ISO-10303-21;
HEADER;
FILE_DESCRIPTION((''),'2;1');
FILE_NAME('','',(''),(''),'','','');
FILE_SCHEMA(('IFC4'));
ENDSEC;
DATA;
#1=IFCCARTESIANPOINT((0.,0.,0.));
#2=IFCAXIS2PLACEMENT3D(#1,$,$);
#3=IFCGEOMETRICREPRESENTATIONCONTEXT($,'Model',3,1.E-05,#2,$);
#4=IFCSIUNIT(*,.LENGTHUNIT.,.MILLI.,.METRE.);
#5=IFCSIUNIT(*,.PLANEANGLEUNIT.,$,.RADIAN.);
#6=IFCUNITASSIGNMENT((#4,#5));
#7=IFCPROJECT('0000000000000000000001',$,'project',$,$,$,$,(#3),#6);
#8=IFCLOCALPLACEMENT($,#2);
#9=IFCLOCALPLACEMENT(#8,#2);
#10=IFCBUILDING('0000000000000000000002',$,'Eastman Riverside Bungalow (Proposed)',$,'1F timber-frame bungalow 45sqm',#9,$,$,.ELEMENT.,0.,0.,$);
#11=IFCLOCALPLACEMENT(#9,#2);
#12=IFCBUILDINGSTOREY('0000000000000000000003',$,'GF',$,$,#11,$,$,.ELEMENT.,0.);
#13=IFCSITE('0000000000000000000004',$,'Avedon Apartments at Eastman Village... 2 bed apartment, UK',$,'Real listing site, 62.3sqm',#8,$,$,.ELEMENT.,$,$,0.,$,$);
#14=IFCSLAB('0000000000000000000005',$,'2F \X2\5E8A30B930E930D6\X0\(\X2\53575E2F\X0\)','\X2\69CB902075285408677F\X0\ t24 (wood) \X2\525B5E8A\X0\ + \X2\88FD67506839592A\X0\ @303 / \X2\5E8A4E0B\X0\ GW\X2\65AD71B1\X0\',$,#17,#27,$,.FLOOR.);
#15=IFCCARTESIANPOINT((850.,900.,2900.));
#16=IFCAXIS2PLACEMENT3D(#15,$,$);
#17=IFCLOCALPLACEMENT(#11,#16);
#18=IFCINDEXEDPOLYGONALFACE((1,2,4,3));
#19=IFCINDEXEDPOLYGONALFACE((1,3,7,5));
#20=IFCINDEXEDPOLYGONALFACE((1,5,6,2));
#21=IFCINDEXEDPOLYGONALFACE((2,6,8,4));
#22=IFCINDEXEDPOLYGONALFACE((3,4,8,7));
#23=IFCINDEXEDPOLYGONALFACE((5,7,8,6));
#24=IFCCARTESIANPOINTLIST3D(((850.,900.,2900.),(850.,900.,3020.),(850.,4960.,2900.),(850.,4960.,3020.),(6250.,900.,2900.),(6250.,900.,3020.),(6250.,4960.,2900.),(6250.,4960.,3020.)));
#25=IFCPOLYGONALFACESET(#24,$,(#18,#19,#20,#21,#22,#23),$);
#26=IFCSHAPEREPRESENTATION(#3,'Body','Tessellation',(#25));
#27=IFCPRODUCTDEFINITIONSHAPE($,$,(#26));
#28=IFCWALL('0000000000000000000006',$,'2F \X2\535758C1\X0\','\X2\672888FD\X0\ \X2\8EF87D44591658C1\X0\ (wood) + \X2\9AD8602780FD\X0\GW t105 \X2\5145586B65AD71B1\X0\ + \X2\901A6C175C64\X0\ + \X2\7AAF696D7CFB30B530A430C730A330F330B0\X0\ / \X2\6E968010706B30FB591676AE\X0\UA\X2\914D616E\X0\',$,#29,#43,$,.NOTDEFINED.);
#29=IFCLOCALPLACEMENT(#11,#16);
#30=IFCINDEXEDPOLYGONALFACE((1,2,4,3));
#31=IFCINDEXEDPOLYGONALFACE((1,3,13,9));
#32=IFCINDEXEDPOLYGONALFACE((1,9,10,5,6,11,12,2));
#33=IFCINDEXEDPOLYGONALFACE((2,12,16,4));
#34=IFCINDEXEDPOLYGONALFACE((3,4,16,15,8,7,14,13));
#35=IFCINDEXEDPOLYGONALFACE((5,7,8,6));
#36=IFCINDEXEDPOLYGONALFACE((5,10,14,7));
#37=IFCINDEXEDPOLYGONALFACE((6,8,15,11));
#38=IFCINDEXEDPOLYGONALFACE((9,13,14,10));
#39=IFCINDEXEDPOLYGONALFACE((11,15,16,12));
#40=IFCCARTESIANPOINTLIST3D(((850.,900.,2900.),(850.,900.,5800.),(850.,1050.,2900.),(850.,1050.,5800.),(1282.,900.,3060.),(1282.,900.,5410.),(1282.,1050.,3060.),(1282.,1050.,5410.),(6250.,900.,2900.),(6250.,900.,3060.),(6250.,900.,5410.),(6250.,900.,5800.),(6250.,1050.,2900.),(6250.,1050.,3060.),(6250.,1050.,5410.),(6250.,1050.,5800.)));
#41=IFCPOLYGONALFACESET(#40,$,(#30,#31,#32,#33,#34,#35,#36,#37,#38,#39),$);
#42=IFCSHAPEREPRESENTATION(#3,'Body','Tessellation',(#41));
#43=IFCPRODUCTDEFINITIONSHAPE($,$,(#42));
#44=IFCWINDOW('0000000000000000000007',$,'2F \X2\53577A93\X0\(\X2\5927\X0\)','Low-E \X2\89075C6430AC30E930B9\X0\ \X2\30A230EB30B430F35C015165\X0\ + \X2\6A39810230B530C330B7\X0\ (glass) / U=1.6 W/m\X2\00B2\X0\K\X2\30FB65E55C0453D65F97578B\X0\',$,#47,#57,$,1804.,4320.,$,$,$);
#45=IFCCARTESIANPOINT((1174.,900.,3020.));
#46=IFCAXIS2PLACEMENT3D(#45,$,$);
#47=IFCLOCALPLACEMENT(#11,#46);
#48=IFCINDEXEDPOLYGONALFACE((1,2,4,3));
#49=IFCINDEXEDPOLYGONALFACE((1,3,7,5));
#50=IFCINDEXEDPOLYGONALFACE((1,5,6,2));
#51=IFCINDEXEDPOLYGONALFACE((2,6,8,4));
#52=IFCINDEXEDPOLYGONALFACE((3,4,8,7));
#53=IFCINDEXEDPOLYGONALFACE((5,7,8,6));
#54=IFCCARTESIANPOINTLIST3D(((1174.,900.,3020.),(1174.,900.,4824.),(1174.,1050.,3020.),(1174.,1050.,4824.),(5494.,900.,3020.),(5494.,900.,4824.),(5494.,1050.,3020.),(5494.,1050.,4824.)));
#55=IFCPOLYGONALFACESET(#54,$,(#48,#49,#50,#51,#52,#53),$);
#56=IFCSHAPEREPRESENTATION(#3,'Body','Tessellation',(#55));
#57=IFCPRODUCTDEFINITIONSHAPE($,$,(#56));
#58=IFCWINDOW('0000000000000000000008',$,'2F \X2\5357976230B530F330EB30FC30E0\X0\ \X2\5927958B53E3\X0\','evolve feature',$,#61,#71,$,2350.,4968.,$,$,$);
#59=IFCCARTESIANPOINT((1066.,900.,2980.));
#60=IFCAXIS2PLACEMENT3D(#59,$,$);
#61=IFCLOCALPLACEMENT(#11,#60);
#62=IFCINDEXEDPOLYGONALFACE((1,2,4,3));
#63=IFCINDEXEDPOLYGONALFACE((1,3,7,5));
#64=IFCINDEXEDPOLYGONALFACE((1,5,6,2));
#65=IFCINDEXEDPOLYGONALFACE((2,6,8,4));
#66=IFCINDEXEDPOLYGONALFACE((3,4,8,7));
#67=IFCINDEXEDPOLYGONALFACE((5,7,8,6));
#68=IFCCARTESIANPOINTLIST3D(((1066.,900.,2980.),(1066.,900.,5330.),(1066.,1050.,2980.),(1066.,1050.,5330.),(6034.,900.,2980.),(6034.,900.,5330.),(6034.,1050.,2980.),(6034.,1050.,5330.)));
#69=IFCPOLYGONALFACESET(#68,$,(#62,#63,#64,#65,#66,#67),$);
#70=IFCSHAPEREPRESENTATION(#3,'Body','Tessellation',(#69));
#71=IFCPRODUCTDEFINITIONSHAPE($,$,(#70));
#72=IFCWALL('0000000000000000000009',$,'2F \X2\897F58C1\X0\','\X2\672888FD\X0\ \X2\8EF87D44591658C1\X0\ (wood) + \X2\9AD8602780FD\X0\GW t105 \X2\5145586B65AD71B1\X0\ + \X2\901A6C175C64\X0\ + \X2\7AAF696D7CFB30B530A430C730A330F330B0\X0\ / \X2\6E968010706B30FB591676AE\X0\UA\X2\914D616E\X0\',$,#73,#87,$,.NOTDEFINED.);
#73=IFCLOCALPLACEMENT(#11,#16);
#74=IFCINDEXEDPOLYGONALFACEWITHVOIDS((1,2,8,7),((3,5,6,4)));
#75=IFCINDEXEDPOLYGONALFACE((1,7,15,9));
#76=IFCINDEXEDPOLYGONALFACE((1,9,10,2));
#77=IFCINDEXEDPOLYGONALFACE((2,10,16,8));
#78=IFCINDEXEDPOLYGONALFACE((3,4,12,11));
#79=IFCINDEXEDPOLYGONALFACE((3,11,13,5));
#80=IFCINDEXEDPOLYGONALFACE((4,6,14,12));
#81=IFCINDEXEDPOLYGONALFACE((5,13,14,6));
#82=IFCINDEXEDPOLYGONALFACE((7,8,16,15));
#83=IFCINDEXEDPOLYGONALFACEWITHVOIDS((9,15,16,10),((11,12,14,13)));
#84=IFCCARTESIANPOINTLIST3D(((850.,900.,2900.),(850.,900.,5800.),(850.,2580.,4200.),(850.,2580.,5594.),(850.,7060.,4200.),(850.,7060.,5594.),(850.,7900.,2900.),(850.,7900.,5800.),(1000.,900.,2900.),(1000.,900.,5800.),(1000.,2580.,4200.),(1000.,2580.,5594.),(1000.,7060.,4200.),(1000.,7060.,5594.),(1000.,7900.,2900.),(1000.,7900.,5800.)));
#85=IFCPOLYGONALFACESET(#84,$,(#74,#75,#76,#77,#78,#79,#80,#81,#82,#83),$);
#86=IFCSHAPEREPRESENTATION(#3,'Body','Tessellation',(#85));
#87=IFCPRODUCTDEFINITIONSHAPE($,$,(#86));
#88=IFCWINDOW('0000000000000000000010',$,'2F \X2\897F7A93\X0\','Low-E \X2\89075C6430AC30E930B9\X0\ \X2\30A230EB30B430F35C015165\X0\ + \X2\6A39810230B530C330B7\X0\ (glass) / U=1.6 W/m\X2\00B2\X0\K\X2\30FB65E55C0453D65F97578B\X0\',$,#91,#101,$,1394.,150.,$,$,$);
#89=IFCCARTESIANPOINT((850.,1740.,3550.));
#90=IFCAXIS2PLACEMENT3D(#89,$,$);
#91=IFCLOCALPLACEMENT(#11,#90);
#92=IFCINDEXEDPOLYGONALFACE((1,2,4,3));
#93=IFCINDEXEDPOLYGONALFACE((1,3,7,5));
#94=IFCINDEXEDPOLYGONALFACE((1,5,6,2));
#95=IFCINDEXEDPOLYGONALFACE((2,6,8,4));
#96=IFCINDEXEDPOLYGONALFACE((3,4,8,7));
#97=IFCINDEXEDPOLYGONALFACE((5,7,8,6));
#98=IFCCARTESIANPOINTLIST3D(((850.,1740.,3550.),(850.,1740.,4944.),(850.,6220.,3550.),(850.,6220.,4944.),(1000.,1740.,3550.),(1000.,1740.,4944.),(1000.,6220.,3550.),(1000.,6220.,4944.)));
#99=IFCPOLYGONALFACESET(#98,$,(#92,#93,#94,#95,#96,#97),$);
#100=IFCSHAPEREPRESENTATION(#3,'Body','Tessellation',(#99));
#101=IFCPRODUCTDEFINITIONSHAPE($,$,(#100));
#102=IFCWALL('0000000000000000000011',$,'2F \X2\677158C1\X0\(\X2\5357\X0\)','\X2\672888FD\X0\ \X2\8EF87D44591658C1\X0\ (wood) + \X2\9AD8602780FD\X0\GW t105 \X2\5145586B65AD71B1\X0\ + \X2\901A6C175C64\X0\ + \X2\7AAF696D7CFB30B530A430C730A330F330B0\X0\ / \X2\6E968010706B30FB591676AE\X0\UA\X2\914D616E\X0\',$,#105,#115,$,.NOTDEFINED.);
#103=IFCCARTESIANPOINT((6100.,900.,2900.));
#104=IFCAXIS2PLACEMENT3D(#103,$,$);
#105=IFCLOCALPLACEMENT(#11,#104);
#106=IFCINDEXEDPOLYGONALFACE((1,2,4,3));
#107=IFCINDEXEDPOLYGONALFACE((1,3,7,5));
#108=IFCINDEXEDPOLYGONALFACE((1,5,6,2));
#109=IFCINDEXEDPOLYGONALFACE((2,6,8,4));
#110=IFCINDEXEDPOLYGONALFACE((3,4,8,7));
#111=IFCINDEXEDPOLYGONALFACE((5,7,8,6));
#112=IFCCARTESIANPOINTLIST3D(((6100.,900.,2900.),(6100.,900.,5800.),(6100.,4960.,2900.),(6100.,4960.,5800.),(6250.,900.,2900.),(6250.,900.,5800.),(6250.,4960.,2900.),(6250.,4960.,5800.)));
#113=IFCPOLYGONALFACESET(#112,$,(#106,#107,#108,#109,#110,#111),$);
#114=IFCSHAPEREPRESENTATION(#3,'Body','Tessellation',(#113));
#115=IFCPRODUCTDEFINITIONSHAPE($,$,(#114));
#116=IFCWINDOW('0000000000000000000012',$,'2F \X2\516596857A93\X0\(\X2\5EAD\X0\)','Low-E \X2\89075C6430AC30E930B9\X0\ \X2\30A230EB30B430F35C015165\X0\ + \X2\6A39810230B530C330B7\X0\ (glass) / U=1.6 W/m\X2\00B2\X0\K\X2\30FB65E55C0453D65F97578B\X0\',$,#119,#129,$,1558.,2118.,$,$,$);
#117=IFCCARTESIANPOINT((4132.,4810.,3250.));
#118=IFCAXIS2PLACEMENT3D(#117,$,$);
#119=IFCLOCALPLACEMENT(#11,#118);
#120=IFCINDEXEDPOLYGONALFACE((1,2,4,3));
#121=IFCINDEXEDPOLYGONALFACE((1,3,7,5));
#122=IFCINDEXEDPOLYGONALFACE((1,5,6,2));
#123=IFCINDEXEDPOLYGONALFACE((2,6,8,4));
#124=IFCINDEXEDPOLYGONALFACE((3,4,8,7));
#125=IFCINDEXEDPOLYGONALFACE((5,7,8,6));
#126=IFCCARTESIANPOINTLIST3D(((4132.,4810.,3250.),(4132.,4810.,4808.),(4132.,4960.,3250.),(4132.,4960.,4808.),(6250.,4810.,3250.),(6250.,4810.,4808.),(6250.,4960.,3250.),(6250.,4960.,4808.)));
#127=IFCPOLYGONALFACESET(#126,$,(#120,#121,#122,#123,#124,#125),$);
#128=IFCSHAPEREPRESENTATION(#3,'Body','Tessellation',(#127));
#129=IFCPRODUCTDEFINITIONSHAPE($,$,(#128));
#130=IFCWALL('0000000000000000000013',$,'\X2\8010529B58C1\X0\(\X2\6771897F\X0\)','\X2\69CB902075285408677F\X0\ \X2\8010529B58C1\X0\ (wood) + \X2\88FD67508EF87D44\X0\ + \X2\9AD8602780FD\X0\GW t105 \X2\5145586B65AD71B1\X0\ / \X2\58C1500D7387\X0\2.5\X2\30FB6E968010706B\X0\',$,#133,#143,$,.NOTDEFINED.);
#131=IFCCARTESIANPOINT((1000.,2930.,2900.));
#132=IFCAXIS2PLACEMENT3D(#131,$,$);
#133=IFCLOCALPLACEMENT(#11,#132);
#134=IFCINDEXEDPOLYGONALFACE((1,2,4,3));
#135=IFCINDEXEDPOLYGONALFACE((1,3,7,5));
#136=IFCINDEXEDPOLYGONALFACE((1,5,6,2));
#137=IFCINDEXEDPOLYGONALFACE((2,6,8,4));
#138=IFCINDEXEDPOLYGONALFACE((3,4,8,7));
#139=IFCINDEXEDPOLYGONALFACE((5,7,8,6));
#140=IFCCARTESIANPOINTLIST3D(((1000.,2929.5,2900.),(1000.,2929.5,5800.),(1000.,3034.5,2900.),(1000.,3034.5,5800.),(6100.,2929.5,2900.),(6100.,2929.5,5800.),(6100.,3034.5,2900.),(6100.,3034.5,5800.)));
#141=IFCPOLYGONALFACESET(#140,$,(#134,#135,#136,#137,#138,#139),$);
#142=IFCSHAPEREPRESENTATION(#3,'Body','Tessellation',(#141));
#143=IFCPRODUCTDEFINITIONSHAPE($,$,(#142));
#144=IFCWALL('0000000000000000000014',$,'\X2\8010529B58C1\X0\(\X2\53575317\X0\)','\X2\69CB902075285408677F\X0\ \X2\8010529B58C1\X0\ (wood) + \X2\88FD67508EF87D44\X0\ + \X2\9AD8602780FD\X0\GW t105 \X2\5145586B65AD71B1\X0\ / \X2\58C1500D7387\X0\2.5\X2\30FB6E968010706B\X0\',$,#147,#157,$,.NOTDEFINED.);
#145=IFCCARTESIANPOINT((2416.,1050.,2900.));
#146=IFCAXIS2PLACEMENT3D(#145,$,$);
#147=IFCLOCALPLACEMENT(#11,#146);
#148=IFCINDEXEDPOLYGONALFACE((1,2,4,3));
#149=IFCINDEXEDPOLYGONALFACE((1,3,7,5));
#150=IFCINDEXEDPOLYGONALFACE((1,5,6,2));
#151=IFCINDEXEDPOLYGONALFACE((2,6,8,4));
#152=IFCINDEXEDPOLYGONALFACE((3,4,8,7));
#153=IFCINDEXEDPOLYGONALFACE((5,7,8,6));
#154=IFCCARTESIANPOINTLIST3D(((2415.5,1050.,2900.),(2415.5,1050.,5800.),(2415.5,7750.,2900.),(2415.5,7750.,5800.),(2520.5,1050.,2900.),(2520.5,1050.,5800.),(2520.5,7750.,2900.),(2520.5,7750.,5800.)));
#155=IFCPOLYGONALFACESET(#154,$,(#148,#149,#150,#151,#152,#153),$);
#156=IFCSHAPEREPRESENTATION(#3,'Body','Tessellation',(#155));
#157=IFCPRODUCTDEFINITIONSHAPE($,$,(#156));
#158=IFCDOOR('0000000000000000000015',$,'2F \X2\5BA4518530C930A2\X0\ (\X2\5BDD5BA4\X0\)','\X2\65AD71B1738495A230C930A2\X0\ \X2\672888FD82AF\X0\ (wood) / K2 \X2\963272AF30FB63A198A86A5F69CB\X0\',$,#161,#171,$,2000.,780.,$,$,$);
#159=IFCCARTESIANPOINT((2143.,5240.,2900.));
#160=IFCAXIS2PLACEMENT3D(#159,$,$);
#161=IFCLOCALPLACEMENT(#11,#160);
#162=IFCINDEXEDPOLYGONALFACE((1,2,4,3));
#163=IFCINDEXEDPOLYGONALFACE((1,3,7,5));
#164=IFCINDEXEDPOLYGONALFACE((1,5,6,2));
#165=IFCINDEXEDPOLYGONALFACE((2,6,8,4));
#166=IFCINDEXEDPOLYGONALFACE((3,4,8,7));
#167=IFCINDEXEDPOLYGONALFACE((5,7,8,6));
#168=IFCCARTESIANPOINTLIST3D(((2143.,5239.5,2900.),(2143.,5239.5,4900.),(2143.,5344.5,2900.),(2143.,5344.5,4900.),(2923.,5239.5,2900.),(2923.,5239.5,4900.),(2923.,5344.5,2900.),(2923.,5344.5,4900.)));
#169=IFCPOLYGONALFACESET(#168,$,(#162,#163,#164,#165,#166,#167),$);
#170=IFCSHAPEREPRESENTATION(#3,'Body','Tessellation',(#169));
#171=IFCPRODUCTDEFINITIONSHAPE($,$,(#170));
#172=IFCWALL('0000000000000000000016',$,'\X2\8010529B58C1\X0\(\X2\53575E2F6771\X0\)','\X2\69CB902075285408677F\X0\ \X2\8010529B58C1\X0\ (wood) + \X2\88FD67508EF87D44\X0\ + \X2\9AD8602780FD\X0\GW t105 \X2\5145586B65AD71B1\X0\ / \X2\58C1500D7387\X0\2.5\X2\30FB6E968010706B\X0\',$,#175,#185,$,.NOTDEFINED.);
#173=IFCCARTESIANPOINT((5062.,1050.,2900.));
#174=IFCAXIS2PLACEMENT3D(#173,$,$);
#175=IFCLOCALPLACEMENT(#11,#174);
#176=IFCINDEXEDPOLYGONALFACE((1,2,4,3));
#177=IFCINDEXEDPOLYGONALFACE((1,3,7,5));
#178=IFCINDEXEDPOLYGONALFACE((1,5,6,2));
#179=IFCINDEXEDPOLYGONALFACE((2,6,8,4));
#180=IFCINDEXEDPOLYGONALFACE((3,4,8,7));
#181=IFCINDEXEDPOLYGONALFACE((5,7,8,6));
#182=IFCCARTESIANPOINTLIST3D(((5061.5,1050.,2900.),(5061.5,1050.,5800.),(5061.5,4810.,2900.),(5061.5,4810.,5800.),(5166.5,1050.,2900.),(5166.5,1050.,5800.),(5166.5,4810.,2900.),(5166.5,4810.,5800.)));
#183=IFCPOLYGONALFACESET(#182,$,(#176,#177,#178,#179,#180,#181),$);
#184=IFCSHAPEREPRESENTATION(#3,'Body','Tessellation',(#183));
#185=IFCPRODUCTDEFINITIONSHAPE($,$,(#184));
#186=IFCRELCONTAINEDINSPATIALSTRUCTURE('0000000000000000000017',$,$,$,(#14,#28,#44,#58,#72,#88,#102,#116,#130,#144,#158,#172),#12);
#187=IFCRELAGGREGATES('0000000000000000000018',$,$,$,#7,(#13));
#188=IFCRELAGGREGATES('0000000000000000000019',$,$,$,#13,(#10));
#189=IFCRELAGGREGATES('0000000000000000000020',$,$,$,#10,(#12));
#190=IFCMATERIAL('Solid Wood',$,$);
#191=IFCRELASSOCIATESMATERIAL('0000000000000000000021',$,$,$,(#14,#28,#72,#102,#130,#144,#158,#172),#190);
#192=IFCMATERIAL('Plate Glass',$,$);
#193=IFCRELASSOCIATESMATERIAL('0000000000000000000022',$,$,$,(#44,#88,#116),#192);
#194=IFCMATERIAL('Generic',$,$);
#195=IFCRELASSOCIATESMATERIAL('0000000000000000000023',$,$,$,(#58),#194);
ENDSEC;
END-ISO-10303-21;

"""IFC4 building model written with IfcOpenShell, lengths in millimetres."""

from ifc_helpers import new_model, si_unit, frame, frame_2d, origin, place, context, project, spatial, rectangle, extrude, material, element, fill, save


model = new_model("IFC4")

# Units and contexts
model_context = context("Model", 3, precision=1e-05, world=origin())
ifc_project = project(units=[si_unit("LENGTHUNIT", "METRE", prefix="MILLI"), si_unit("PLANEANGLEUNIT", "RADIAN")], contexts=[model_context])

# Site, building, storey
site_placement = place(None, origin())
site = spatial("IfcSite", under=ifc_project, at=site_placement, Name="Avedon Apartments at Eastman Village... 2 bed apartment, UK", ObjectType="Real listing site, 62.3sqm", CompositionType="ELEMENT", RefElevation=0.0)
building_placement = place(site_placement, origin())
building = spatial("IfcBuilding", under=site, at=building_placement, Name="Eastman Riverside Bungalow (Proposed)", ObjectType="1F timber-frame bungalow 45sqm", CompositionType="ELEMENT", ElevationOfRefHeight=0.0, ElevationOfTerrain=0.0)
storey_placement = place(building_placement, origin())
storey = spatial("IfcBuildingStorey", under=building, at=storey_placement, Name="GF", CompositionType="ELEMENT", Elevation=0.0)

# Slab
ifc_material_1 = material(Name="Solid Wood")
slab_placement = place(storey_placement, frame((850.0, 900.0, 2900.0)))
element("IfcSlab", 1, at=slab_placement, inside=storey, material=ifc_material_1, Name="2F 床スラブ(南帯)", Description="構造用合板 t24 (wood) 剛床 + 製材根太 @303 / 床下 GW断熱", PredefinedType="FLOOR", context=model_context, shape_type="SweptSolid", body=[
    extrude(rectangle(XDim=5400.0, YDim=4060.0, at=frame_2d((2700.0, 2030.0))), frame((850.0, 900.0, 2900.0)), (0.0, 0.0, 1.0), 120.0),
])

# Wall, openings, windows
wall_1_placement = place(storey_placement, frame((850.0, 900.0, 2900.0)))
wall_1 = element("IfcWall", 2, at=wall_1_placement, inside=storey, material=ifc_material_1, Name="2F 南壁", Description="木製 軸組外壁 (wood) + 高性能GW t105 充填断熱 + 通気層 + 窯業系サイディング / 準耐火・外皮UA配慮", PredefinedType="NOTDEFINED", context=model_context, shape_type="SweptSolid", body=[
    extrude(rectangle(XDim=5400.0, YDim=150.0, at=frame_2d((2700.0, 75.0))), frame((850.0, 900.0, 2900.0)), (0.0, 0.0, 1.0), 2900.0),
])
opening_1_placement = place(storey_placement, frame((1174.0, 900.0, 3020.0)))
opening_1 = element("IfcOpeningElement", 3, at=opening_1_placement, cuts=wall_1, PredefinedType="NOTDEFINED", context=model_context, shape_type="SweptSolid", body=[
    extrude(rectangle(XDim=4320.0, YDim=150.0, at=frame_2d((2160.0, 75.0))), frame((1174.0, 900.0, 3020.0)), (0.0, 0.0, 1.0), 1804.0),
])
opening_2_placement = place(storey_placement, frame((1066.0, 900.0, 2980.0)))
opening_2 = element("IfcOpeningElement", 4, at=opening_2_placement, cuts=wall_1, PredefinedType="NOTDEFINED", context=model_context, shape_type="SweptSolid", body=[
    extrude(rectangle(XDim=4968.0, YDim=150.0, at=frame_2d((2484.0, 75.0))), frame((1066.0, 900.0, 2980.0)), (0.0, 0.0, 1.0), 2350.0),
])
ifc_material_2 = material(Name="Plate Glass")
window_1_placement = place(storey_placement, frame((1174.0, 900.0, 3020.0)))
window_1 = element("IfcWindow", 5, at=window_1_placement, inside=storey, material=ifc_material_2, Name="2F 南窓(大)", Description="Low-E 複層ガラス アルゴン封入 + 樹脂サッシ (glass) / U=1.6 W/m²K・日射取得型", OverallHeight=1804.0, OverallWidth=4320.0, context=model_context, shape_type="SweptSolid", body=[
    extrude(rectangle(XDim=4320.0, YDim=150.0, at=frame_2d((2160.0, 75.0))), frame((1174.0, 900.0, 3020.0)), (0.0, 0.0, 1.0), 1804.0),
])
fill(opening_1, window_1)
ifc_material_3 = material(Name="Generic")
window_2_placement = place(storey_placement, frame((1066.0, 900.0, 2980.0)))
window_2 = element("IfcWindow", 6, at=window_2_placement, inside=storey, material=ifc_material_3, Name="2F 南面サンルーム 大開口", Description="evolve feature", OverallHeight=2350.0, OverallWidth=4968.0, context=model_context, shape_type="SweptSolid", body=[
    extrude(rectangle(XDim=4968.0, YDim=150.0, at=frame_2d((2484.0, 75.0))), frame((1066.0, 900.0, 2980.0)), (0.0, 0.0, 1.0), 2350.0),
])
fill(opening_2, window_2)

# Walls, openings, windows
wall_2_placement = place(storey_placement, frame((850.0, 900.0, 2900.0)))
wall_2 = element("IfcWall", 7, at=wall_2_placement, inside=storey, material=ifc_material_1, Name="2F 西壁", Description="木製 軸組外壁 (wood) + 高性能GW t105 充填断熱 + 通気層 + 窯業系サイディング / 準耐火・外皮UA配慮", PredefinedType="NOTDEFINED", context=model_context, shape_type="SweptSolid", body=[
    extrude(rectangle(XDim=150.0, YDim=7000.0, at=frame_2d((75.0, 3500.0))), frame((850.0, 900.0, 2900.0)), (0.0, 0.0, 1.0), 2900.0),
])
opening_3_placement = place(storey_placement, frame((850.0, 1740.0, 3550.0)))
opening_3 = element("IfcOpeningElement", 8, at=opening_3_placement, cuts=wall_2, PredefinedType="NOTDEFINED", context=model_context, shape_type="SweptSolid", body=[
    extrude(rectangle(XDim=150.0, YDim=4480.0, at=frame_2d((75.0, 2240.0))), frame((850.0, 1740.0, 3550.0)), (0.0, 0.0, 1.0), 1394.0),
])
window_3_placement = place(storey_placement, frame((850.0, 1740.0, 3550.0)))
window_3 = element("IfcWindow", 9, at=window_3_placement, inside=storey, material=ifc_material_2, Name="2F 西窓", Description="Low-E 複層ガラス アルゴン封入 + 樹脂サッシ (glass) / U=1.6 W/m²K・日射取得型", OverallHeight=1394.0, OverallWidth=150.0, context=model_context, shape_type="SweptSolid", body=[
    extrude(rectangle(XDim=150.0, YDim=4480.0, at=frame_2d((75.0, 2240.0))), frame((850.0, 1740.0, 3550.0)), (0.0, 0.0, 1.0), 1394.0),
])
fill(opening_3, window_3)
wall_3_placement = place(storey_placement, frame((6100.0, 900.0, 2900.0)))
wall_3 = element("IfcWall", 10, at=wall_3_placement, inside=storey, material=ifc_material_1, Name="2F 東壁(南)", Description="木製 軸組外壁 (wood) + 高性能GW t105 充填断熱 + 通気層 + 窯業系サイディング / 準耐火・外皮UA配慮", PredefinedType="NOTDEFINED", context=model_context, shape_type="SweptSolid", body=[
    extrude(rectangle(XDim=150.0, YDim=4060.0, at=frame_2d((75.0, 2030.0))), frame((6100.0, 900.0, 2900.0)), (0.0, 0.0, 1.0), 2900.0),
])
opening_4_placement = place(storey_placement, frame((4132.0, 4810.0, 3250.0)))
opening_4 = element("IfcOpeningElement", 11, at=opening_4_placement, cuts=wall_3, PredefinedType="NOTDEFINED", context=model_context, shape_type="SweptSolid", body=[
    extrude(rectangle(XDim=2118.0, YDim=150.0, at=frame_2d((1059.0, 75.0))), frame((4132.0, 4810.0, 3250.0)), (0.0, 0.0, 1.0), 1558.0),
])
window_4_placement = place(storey_placement, frame((4132.0, 4810.0, 3250.0)))
window_4 = element("IfcWindow", 12, at=window_4_placement, inside=storey, material=ifc_material_2, Name="2F 入隅窓(庭)", Description="Low-E 複層ガラス アルゴン封入 + 樹脂サッシ (glass) / U=1.6 W/m²K・日射取得型", OverallHeight=1558.0, OverallWidth=2118.0, context=model_context, shape_type="SweptSolid", body=[
    extrude(rectangle(XDim=2118.0, YDim=150.0, at=frame_2d((1059.0, 75.0))), frame((4132.0, 4810.0, 3250.0)), (0.0, 0.0, 1.0), 1558.0),
])
fill(opening_4, window_4)

# Wall
wall_4_placement = place(storey_placement, frame((1000.0, 2930.0, 2900.0)))
element("IfcWall", 13, at=wall_4_placement, inside=storey, material=ifc_material_1, Name="耐力壁(東西)", Description="構造用合板 耐力壁 (wood) + 製材軸組 + 高性能GW t105 充填断熱 / 壁倍率2.5・準耐火", PredefinedType="NOTDEFINED", context=model_context, shape_type="SweptSolid", body=[
    extrude(rectangle(XDim=5100.0, YDim=105.0, at=frame_2d((2550.0, 52.0))), frame((1000.0, 2930.0, 2900.0)), (0.0, 0.0, 1.0), 2900.0),
])

# Wall, opening, door
wall_5_placement = place(storey_placement, frame((2416.0, 1050.0, 2900.0)))
wall_5 = element("IfcWall", 14, at=wall_5_placement, inside=storey, material=ifc_material_1, Name="耐力壁(南北)", Description="構造用合板 耐力壁 (wood) + 製材軸組 + 高性能GW t105 充填断熱 / 壁倍率2.5・準耐火", PredefinedType="NOTDEFINED", context=model_context, shape_type="SweptSolid", body=[
    extrude(rectangle(XDim=105.0, YDim=6700.0, at=frame_2d((52.0, 3350.0))), frame((2416.0, 1050.0, 2900.0)), (0.0, 0.0, 1.0), 2900.0),
])
opening_5_placement = place(storey_placement, frame((2143.0, 5240.0, 2900.0)))
opening_5 = element("IfcOpeningElement", 15, at=opening_5_placement, cuts=wall_5, PredefinedType="NOTDEFINED", context=model_context, shape_type="SweptSolid", body=[
    extrude(rectangle(XDim=780.0, YDim=105.0, at=frame_2d((390.0, 52.0))), frame((2143.0, 5240.0, 2900.0)), (0.0, 0.0, 1.0), 2000.0),
])
door_placement = place(storey_placement, frame((2143.0, 5240.0, 2900.0)))
door = element("IfcDoor", 16, at=door_placement, inside=storey, material=ifc_material_1, Name="2F 室内ドア (寝室)", Description="断熱玄関ドア 木製芯 (wood) / K2 防犯・採風機構", OverallHeight=2000.0, OverallWidth=780.0, context=model_context, shape_type="SweptSolid", body=[
    extrude(rectangle(XDim=780.0, YDim=105.0, at=frame_2d((390.0, 52.0))), frame((2143.0, 5240.0, 2900.0)), (0.0, 0.0, 1.0), 2000.0),
])
fill(opening_5, door)

# Wall
wall_6_placement = place(storey_placement, frame((5062.0, 1050.0, 2900.0)))
element("IfcWall", 17, at=wall_6_placement, inside=storey, material=ifc_material_1, Name="耐力壁(南帯東)", Description="構造用合板 耐力壁 (wood) + 製材軸組 + 高性能GW t105 充填断熱 / 壁倍率2.5・準耐火", PredefinedType="NOTDEFINED", context=model_context, shape_type="SweptSolid", body=[
    extrude(rectangle(XDim=105.0, YDim=3760.0, at=frame_2d((52.0, 1880.0))), frame((5062.0, 1050.0, 2900.0)), (0.0, 0.0, 1.0), 2900.0),
])

save(model, "model.ifc")
